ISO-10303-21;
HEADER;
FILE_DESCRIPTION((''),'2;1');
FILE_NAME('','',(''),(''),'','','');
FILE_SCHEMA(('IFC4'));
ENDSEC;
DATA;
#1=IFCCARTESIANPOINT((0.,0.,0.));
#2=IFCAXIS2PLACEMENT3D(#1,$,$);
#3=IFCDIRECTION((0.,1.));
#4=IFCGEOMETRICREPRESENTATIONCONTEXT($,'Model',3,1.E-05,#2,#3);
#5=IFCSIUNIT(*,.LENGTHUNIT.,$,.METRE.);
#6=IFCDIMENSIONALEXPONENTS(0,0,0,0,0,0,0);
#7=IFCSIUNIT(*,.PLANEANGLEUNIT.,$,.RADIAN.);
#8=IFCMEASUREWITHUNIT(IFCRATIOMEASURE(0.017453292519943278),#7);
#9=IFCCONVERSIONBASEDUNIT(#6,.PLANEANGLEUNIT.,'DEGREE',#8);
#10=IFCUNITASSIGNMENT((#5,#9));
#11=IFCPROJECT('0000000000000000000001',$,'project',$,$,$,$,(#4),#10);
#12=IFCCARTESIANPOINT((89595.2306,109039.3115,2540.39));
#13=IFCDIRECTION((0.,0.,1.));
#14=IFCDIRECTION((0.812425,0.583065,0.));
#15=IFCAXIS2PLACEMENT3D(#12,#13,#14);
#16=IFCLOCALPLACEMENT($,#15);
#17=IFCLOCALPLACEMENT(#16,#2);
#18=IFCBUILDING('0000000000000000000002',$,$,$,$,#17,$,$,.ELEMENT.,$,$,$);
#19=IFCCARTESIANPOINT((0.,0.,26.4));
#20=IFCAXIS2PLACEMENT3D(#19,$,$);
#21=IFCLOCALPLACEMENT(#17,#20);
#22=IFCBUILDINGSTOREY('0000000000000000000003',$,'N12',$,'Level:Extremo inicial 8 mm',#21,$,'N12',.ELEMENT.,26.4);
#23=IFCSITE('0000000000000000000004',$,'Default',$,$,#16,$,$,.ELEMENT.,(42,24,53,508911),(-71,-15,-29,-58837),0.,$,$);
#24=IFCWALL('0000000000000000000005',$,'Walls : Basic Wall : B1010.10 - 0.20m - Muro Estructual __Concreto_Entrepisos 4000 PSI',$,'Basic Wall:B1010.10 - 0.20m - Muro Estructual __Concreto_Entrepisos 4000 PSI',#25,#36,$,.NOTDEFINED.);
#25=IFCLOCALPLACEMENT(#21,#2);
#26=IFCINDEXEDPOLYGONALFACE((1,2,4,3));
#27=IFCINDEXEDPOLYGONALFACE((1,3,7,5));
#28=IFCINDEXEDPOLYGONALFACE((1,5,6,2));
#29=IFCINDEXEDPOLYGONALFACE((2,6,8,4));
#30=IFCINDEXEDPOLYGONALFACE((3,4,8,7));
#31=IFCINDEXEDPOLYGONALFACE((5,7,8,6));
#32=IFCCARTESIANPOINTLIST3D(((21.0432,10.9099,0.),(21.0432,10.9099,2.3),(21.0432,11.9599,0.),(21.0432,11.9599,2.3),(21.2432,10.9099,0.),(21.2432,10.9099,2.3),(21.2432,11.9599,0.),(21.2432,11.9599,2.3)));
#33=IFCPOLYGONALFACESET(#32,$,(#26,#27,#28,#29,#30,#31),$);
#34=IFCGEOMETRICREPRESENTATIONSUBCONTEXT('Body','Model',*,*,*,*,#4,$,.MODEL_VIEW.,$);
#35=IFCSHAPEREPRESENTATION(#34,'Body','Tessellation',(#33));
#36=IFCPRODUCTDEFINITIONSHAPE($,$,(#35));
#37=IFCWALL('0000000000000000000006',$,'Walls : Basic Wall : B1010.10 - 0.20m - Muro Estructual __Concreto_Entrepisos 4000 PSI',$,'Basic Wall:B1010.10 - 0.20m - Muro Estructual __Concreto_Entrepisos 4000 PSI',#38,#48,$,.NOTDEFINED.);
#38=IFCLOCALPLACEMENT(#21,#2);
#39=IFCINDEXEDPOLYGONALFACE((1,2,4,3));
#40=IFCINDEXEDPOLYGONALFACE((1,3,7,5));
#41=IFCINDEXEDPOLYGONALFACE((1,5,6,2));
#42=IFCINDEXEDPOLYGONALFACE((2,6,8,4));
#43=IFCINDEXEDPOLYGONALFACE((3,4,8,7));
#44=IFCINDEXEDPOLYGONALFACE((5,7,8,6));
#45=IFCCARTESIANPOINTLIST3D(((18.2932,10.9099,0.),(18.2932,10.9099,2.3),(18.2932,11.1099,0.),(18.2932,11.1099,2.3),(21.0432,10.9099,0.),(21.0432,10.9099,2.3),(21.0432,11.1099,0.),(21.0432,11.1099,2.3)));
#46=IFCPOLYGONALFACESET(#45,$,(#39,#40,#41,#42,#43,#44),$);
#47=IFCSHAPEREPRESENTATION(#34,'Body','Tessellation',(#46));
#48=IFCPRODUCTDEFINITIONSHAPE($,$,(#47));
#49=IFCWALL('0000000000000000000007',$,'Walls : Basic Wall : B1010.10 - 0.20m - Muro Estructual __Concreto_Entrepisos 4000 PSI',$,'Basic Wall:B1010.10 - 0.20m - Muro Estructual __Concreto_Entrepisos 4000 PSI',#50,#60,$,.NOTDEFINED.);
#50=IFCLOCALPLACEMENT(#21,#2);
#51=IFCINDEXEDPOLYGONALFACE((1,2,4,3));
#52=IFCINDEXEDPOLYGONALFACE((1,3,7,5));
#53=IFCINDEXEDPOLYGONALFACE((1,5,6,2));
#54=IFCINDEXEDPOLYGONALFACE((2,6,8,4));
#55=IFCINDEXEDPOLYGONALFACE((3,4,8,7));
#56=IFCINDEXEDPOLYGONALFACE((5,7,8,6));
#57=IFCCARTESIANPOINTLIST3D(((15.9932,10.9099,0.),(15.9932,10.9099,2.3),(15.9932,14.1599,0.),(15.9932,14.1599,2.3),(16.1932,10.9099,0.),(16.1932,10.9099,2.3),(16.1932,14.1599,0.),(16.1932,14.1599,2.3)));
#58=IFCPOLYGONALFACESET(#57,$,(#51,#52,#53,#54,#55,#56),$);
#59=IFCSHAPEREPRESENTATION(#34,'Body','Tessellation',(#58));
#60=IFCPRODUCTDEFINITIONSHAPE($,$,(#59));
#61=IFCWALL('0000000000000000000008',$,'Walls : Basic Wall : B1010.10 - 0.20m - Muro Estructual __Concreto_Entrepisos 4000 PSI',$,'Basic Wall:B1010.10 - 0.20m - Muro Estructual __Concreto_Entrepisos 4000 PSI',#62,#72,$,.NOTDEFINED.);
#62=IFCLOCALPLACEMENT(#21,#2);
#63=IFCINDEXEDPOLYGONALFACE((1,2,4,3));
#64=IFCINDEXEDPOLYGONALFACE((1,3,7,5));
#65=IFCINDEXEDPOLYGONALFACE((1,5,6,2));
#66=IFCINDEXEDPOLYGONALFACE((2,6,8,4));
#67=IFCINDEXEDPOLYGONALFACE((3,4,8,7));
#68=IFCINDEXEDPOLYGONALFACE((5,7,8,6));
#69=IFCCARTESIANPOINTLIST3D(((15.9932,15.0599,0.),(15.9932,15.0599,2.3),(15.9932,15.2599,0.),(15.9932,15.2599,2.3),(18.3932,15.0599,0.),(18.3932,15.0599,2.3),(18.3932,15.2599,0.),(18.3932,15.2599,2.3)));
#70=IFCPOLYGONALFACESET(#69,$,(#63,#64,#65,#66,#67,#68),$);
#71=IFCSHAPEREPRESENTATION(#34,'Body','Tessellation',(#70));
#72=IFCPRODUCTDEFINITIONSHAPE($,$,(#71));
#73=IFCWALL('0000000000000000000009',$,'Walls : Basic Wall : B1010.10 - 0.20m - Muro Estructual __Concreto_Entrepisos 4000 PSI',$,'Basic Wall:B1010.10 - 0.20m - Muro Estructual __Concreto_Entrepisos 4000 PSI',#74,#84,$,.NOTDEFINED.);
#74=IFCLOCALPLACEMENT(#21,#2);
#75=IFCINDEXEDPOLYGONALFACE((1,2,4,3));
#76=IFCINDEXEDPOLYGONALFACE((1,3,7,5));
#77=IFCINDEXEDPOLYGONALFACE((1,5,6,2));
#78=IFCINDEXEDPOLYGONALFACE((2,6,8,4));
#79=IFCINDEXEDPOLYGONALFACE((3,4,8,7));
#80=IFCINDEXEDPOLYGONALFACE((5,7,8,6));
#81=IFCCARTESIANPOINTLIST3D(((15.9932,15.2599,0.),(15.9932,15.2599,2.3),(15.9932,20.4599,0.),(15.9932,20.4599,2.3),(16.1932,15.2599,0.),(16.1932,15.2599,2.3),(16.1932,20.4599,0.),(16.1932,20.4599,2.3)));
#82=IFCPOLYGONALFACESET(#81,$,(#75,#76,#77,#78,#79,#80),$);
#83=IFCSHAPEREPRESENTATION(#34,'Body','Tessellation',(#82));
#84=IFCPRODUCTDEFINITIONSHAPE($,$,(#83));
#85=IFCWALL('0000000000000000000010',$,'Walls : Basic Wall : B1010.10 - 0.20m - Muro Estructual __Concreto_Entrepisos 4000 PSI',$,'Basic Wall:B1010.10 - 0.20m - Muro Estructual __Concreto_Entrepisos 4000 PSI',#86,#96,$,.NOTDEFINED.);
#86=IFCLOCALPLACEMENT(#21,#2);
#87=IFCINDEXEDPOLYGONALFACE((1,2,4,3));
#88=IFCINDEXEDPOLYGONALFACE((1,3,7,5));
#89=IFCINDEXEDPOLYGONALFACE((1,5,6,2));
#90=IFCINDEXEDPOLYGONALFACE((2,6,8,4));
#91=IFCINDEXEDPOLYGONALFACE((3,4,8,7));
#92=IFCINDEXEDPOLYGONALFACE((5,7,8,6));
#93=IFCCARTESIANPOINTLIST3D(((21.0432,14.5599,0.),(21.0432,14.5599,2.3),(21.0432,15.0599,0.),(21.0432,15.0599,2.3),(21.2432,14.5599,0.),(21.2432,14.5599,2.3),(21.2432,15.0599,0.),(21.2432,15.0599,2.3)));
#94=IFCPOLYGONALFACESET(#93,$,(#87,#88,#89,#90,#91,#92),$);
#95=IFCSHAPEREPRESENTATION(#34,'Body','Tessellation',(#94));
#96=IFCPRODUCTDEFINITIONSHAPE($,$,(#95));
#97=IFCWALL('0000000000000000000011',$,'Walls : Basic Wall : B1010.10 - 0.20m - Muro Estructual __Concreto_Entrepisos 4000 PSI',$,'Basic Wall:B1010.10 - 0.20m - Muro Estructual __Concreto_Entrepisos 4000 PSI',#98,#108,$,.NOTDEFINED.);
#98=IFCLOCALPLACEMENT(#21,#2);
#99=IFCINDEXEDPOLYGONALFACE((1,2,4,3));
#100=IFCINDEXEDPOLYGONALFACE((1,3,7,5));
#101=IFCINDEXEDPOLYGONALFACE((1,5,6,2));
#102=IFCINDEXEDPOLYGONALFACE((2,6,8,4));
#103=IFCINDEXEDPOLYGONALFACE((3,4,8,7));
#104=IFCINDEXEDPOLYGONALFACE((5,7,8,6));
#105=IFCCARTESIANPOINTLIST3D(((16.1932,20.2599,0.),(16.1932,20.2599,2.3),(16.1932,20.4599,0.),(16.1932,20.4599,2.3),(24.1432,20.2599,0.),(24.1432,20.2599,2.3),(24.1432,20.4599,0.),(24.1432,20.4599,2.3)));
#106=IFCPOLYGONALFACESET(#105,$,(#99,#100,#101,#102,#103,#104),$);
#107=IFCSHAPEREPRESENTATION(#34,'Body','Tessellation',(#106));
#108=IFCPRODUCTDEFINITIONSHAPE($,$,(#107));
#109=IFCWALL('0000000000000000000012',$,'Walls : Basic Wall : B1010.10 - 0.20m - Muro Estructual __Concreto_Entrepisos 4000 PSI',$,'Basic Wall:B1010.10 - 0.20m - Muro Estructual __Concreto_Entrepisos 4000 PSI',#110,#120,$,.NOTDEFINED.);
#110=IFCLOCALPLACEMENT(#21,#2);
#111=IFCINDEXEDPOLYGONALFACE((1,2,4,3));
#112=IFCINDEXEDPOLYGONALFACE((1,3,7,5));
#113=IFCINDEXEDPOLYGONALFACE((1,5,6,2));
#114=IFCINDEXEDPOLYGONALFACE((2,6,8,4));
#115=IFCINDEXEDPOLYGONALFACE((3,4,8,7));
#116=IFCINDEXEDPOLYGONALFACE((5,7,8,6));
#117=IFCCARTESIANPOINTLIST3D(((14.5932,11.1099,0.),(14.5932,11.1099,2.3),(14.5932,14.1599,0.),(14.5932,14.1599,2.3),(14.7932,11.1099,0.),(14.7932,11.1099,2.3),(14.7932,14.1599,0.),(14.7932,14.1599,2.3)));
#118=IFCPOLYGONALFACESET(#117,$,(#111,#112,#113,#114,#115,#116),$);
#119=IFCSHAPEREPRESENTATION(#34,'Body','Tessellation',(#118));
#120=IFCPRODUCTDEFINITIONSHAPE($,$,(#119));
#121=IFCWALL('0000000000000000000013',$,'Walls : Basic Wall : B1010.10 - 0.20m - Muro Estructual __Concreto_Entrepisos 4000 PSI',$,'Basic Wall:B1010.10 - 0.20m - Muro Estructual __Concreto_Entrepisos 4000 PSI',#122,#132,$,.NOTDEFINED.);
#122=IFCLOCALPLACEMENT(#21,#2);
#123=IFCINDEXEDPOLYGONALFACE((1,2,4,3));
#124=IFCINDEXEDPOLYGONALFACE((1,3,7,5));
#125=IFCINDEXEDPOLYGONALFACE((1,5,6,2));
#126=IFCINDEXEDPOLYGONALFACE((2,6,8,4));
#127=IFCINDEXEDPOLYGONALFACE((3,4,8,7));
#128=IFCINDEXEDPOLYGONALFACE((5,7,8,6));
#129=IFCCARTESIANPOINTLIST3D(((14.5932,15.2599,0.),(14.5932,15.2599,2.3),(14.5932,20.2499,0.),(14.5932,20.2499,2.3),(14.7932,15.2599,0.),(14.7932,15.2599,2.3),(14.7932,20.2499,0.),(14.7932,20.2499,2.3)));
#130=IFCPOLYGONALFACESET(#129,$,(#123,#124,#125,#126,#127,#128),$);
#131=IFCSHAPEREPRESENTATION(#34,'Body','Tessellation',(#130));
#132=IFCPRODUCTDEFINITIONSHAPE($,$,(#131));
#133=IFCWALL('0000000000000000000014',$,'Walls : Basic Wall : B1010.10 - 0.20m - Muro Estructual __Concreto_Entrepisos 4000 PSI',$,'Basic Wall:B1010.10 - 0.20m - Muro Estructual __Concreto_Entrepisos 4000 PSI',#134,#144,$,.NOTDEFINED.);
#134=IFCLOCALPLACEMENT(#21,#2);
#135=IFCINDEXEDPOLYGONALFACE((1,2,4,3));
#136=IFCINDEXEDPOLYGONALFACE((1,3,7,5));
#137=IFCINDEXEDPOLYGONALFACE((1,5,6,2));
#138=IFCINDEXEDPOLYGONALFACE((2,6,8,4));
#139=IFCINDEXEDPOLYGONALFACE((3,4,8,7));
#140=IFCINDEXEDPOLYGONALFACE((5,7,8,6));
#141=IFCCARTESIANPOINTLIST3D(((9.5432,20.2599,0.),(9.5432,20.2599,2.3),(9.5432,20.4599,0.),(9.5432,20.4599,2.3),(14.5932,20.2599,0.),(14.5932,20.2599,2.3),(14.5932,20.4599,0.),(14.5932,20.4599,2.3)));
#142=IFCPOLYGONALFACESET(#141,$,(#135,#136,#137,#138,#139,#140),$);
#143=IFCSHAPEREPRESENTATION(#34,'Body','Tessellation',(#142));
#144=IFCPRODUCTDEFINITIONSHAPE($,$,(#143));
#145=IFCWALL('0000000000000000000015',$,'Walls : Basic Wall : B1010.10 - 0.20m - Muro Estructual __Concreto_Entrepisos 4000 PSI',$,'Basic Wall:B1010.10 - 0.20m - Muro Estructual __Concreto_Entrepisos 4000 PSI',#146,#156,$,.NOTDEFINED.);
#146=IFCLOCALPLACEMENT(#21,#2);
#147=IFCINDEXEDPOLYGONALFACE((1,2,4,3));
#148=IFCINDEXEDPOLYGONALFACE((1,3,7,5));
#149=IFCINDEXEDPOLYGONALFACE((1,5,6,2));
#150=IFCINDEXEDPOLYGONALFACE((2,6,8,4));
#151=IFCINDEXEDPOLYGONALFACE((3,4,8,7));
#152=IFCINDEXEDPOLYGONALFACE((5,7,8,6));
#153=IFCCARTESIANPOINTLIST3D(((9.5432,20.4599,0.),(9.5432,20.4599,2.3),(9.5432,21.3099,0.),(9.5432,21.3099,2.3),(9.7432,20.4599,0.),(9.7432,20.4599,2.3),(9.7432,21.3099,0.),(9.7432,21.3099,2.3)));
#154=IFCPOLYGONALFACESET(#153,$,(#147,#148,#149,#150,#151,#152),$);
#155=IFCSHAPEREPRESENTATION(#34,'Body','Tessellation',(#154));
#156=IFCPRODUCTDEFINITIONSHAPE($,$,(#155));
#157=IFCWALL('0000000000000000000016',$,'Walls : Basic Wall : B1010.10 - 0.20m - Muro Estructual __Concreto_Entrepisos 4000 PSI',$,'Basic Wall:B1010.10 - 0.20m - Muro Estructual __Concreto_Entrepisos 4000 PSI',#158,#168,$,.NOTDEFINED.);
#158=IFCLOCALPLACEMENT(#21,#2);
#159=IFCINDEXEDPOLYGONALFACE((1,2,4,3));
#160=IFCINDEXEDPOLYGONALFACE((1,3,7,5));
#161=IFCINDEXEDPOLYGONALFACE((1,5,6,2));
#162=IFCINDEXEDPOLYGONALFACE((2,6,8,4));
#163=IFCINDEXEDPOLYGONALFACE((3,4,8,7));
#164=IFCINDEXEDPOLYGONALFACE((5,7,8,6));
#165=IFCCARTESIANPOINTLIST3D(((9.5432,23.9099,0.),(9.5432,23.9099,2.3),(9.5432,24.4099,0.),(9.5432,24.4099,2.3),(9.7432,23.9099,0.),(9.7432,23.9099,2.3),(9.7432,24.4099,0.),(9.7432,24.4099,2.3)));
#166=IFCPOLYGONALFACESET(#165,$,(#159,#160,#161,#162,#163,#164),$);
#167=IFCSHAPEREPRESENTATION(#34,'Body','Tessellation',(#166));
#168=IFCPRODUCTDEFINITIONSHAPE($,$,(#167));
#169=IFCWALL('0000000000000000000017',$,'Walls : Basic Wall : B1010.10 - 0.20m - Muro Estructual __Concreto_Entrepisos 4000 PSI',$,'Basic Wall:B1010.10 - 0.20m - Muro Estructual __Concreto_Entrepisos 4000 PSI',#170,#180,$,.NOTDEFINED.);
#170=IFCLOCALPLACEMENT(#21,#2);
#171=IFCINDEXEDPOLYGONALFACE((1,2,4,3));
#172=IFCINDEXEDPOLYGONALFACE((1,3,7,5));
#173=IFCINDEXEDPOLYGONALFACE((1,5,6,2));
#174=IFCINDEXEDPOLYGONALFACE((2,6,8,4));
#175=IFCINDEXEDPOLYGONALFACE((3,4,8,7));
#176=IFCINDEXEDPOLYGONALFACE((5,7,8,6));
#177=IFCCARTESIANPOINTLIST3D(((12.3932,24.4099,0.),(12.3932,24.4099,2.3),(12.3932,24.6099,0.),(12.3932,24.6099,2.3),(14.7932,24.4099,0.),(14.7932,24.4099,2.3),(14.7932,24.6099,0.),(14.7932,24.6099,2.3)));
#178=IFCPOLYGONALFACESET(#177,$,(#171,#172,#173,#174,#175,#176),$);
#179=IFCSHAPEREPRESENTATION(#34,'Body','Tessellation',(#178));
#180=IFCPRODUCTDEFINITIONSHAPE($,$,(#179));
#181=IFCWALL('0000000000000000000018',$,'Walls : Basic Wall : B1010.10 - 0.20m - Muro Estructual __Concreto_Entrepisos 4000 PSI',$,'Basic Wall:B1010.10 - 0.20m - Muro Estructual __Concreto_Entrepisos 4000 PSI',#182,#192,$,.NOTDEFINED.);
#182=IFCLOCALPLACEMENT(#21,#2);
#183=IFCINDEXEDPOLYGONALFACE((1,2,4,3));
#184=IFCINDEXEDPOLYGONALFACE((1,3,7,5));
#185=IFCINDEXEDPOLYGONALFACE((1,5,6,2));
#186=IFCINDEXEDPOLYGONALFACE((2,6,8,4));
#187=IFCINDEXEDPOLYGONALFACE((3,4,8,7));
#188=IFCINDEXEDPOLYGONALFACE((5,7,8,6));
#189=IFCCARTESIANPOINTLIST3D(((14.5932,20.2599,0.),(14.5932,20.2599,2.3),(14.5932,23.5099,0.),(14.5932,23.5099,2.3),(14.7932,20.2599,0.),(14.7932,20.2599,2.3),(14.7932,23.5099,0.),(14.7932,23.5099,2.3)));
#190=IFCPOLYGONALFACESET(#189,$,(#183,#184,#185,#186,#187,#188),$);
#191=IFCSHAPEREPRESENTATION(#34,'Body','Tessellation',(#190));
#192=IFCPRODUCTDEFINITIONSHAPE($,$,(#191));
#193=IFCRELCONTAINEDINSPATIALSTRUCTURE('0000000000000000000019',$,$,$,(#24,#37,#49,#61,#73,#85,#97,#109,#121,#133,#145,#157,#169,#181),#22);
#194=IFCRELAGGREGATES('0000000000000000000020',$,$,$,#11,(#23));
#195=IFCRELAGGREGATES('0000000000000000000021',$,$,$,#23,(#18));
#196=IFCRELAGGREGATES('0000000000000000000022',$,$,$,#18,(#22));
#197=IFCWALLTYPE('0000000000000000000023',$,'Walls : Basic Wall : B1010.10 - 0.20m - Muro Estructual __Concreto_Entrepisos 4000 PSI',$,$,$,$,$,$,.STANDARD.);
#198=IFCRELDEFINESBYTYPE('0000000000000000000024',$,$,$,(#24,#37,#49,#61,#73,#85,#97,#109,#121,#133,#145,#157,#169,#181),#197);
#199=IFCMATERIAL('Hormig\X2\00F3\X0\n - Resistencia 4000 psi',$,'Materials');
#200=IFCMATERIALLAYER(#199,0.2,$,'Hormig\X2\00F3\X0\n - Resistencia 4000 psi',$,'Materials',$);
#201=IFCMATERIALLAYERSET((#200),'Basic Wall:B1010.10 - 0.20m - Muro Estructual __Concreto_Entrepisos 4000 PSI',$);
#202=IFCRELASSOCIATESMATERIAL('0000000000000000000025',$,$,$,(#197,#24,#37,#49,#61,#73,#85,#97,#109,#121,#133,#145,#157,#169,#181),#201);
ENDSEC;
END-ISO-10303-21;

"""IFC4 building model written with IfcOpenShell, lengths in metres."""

from ifc_helpers import new_model, entity, si_unit, converted_unit, direction, frame, frame_2d, origin, place, context, subcontext, project, spatial, rectangle, extrude, material, layer, layer_set, layer_usage, type_object, element, save


model = new_model("IFC4")

# Units and contexts
model_context = context("Model", 3, precision=1e-05, world=origin(), true_north=direction((0.0, 1.0)))
body_context = subcontext(model_context, "Body", "Model", "MODEL_VIEW")
ifc_project = project(units=[si_unit("LENGTHUNIT", "METRE"), converted_unit("PLANEANGLEUNIT", "DEGREE", entity("IfcRatioMeasure", 0.017453292519943278), si_unit("PLANEANGLEUNIT", "RADIAN"), dimensions=[0, 0, 0, 0, 0, 0, 0])], contexts=[model_context])

# Site, building, storey
site_placement = place(None, frame((89595.2306, 109039.3115, 2540.39), z_axis=(0.0, 0.0, 1.0), x_axis=(0.812425, 0.583065, 0.0)))
site = spatial("IfcSite", under=ifc_project, at=site_placement, Name="Default", CompositionType="ELEMENT", RefLatitude=(42, 24, 53, 508911), RefLongitude=(-71, -15, -29, -58837), RefElevation=0.0)
building_placement = place(site_placement, origin())
building = spatial("IfcBuilding", under=site, at=building_placement, CompositionType="ELEMENT")
storey_placement = place(building_placement, frame((0.0, 0.0, 26.4)))
storey = spatial("IfcBuildingStorey", under=building, at=storey_placement, Name="N12", ObjectType="Level:Extremo inicial 8 mm", LongName="N12", CompositionType="ELEMENT", Elevation=26.4)

# Walls
ifc_material = material(Name="Hormigón - Resistencia 4000 psi", Category="Materials")
ifc_layer_1 = layer(ifc_material, 0.2, Name="Hormigón - Resistencia 4000 psi", Category="Materials")
ifc_layer_set_1 = layer_set([ifc_layer_1], Name="Basic Wall:B1010.10 - 0.20m - Muro Estructual __Concreto_Entrepisos 4000 PSI")
ifc_layer_usage_1 = layer_usage(ifc_layer_set_1, "AXIS2", "NEGATIVE", 0.1)
wall_type_1 = type_object("IfcWallType", Name="Walls : Basic Wall : B1010.10 - 0.20m - Muro Estructual __Concreto_Entrepisos 4000 PSI", PredefinedType="STANDARD", material=ifc_layer_set_1)
wall_1_placement = place(storey_placement, frame((21.1432, 11.9599, 0.0), z_axis=(0.0, 0.0, 1.0), x_axis=(0.0, -1.0, 0.0)))
element("IfcWall", 1, at=wall_1_placement, inside=storey, type_object=wall_type_1, material=ifc_layer_usage_1, Name="Walls : Basic Wall : B1010.10 - 0.20m - Muro Estructual __Concreto_Entrepisos 4000 PSI", ObjectType="Basic Wall:B1010.10 - 0.20m - Muro Estructual __Concreto_Entrepisos 4000 PSI", PredefinedType="NOTDEFINED", context=body_context, shape_type="SweptSolid", body=[
    extrude(rectangle(XDim=1.05, YDim=0.2, at=frame_2d((0.525, 0.0), x_axis=(-1.0, 0.0))), origin(), (0.0, 0.0, 1.0), 2.3),
])
ifc_layer_usage_2 = layer_usage(ifc_layer_set_1, "AXIS2", "NEGATIVE", 0.1)
wall_2_placement = place(storey_placement, frame((21.0432, 11.0099, 0.0), z_axis=(0.0, 0.0, 1.0), x_axis=(-1.0, 0.0, 0.0)))
element("IfcWall", 2, at=wall_2_placement, inside=storey, type_object=wall_type_1, material=ifc_layer_usage_2, Name="Walls : Basic Wall : B1010.10 - 0.20m - Muro Estructual __Concreto_Entrepisos 4000 PSI", ObjectType="Basic Wall:B1010.10 - 0.20m - Muro Estructual __Concreto_Entrepisos 4000 PSI", PredefinedType="NOTDEFINED", context=body_context, shape_type="SweptSolid", body=[
    extrude(rectangle(XDim=2.75, YDim=0.2, at=frame_2d((1.375, 0.0), x_axis=(-1.0, 0.0))), origin(), (0.0, 0.0, 1.0), 2.3),
])
ifc_layer_usage_3 = layer_usage(ifc_layer_set_1, "AXIS2", "NEGATIVE", 0.1)
wall_3_placement = place(storey_placement, frame((16.0932, 14.1599, 0.0), z_axis=(0.0, 0.0, 1.0), x_axis=(0.0, -1.0, 0.0)))
element("IfcWall", 3, at=wall_3_placement, inside=storey, type_object=wall_type_1, material=ifc_layer_usage_3, Name="Walls : Basic Wall : B1010.10 - 0.20m - Muro Estructual __Concreto_Entrepisos 4000 PSI", ObjectType="Basic Wall:B1010.10 - 0.20m - Muro Estructual __Concreto_Entrepisos 4000 PSI", PredefinedType="NOTDEFINED", context=body_context, shape_type="SweptSolid", body=[
    extrude(rectangle(XDim=3.25, YDim=0.2, at=frame_2d((1.625, 0.0), x_axis=(-1.0, 0.0))), origin(), (0.0, 0.0, 1.0), 2.3),
])
ifc_layer_usage_4 = layer_usage(ifc_layer_set_1, "AXIS2", "NEGATIVE", 0.1)
wall_4_placement = place(storey_placement, frame((18.3932, 15.1599, 0.0), z_axis=(0.0, 0.0, 1.0), x_axis=(-1.0, 0.0, 0.0)))
element("IfcWall", 4, at=wall_4_placement, inside=storey, type_object=wall_type_1, material=ifc_layer_usage_4, Name="Walls : Basic Wall : B1010.10 - 0.20m - Muro Estructual __Concreto_Entrepisos 4000 PSI", ObjectType="Basic Wall:B1010.10 - 0.20m - Muro Estructual __Concreto_Entrepisos 4000 PSI", PredefinedType="NOTDEFINED", context=body_context, shape_type="SweptSolid", body=[
    extrude(rectangle(XDim=2.4, YDim=0.2, at=frame_2d((1.2, 0.0), x_axis=(-1.0, 0.0))), origin(), (0.0, 0.0, 1.0), 2.3),
])
ifc_layer_usage_5 = layer_usage(ifc_layer_set_1, "AXIS2", "NEGATIVE", 0.1)
wall_5_placement = place(storey_placement, frame((16.0932, 15.2599, 0.0), z_axis=(0.0, 0.0, 1.0), x_axis=(0.0, 1.0, 0.0)))
element("IfcWall", 5, at=wall_5_placement, inside=storey, type_object=wall_type_1, material=ifc_layer_usage_5, Name="Walls : Basic Wall : B1010.10 - 0.20m - Muro Estructual __Concreto_Entrepisos 4000 PSI", ObjectType="Basic Wall:B1010.10 - 0.20m - Muro Estructual __Concreto_Entrepisos 4000 PSI", PredefinedType="NOTDEFINED", context=body_context, shape_type="SweptSolid", body=[
    extrude(rectangle(XDim=5.2, YDim=0.2, at=frame_2d((2.6, 0.0), x_axis=(-1.0, 0.0))), origin(), (0.0, 0.0, 1.0), 2.3),
])
ifc_layer_usage_6 = layer_usage(ifc_layer_set_1, "AXIS2", "NEGATIVE", 0.1)
wall_6_placement = place(storey_placement, frame((21.1432, 14.5599, 0.0), z_axis=(0.0, 0.0, 1.0), x_axis=(0.0, 1.0, 0.0)))
element("IfcWall", 6, at=wall_6_placement, inside=storey, type_object=wall_type_1, material=ifc_layer_usage_6, Name="Walls : Basic Wall : B1010.10 - 0.20m - Muro Estructual __Concreto_Entrepisos 4000 PSI", ObjectType="Basic Wall:B1010.10 - 0.20m - Muro Estructual __Concreto_Entrepisos 4000 PSI", PredefinedType="NOTDEFINED", context=body_context, shape_type="SweptSolid", body=[
    extrude(rectangle(XDim=0.5, YDim=0.2, at=frame_2d((0.25, 0.0), x_axis=(-1.0, 0.0))), origin(), (0.0, 0.0, 1.0), 2.3),
])
ifc_layer_usage_7 = layer_usage(ifc_layer_set_1, "AXIS2", "NEGATIVE", 0.1)
wall_7_placement = place(storey_placement, frame((16.1932, 20.3599, 0.0)))
element("IfcWall", 7, at=wall_7_placement, inside=storey, type_object=wall_type_1, material=ifc_layer_usage_7, Name="Walls : Basic Wall : B1010.10 - 0.20m - Muro Estructual __Concreto_Entrepisos 4000 PSI", ObjectType="Basic Wall:B1010.10 - 0.20m - Muro Estructual __Concreto_Entrepisos 4000 PSI", PredefinedType="NOTDEFINED", context=body_context, shape_type="SweptSolid", body=[
    extrude(rectangle(XDim=7.95, YDim=0.2, at=frame_2d((3.975, 0.0), x_axis=(-1.0, 0.0))), origin(), (0.0, 0.0, 1.0), 2.3),
])
ifc_layer_usage_8 = layer_usage(ifc_layer_set_1, "AXIS2", "POSITIVE", -0.1)
wall_8_placement = place(storey_placement, frame((14.6932, 14.1599, 0.0), z_axis=(0.0, 0.0, 1.0), x_axis=(0.0, -1.0, 0.0)))
element("IfcWall", 8, at=wall_8_placement, inside=storey, type_object=wall_type_1, material=ifc_layer_usage_8, Name="Walls : Basic Wall : B1010.10 - 0.20m - Muro Estructual __Concreto_Entrepisos 4000 PSI", ObjectType="Basic Wall:B1010.10 - 0.20m - Muro Estructual __Concreto_Entrepisos 4000 PSI", PredefinedType="NOTDEFINED", context=body_context, shape_type="SweptSolid", body=[
    extrude(rectangle(XDim=3.05, YDim=0.2, at=frame_2d((1.525, 0.0), x_axis=(-1.0, 0.0))), origin(), (0.0, 0.0, 1.0), 2.3),
])
ifc_layer_usage_9 = layer_usage(ifc_layer_set_1, "AXIS2", "POSITIVE", -0.1)
wall_9_placement = place(storey_placement, frame((14.6932, 15.2599, 0.0), z_axis=(0.0, 0.0, 1.0), x_axis=(0.0, 1.0, 0.0)))
element("IfcWall", 9, at=wall_9_placement, inside=storey, type_object=wall_type_1, material=ifc_layer_usage_9, Name="Walls : Basic Wall : B1010.10 - 0.20m - Muro Estructual __Concreto_Entrepisos 4000 PSI", ObjectType="Basic Wall:B1010.10 - 0.20m - Muro Estructual __Concreto_Entrepisos 4000 PSI", PredefinedType="NOTDEFINED", context=body_context, shape_type="SweptSolid", body=[
    extrude(rectangle(XDim=4.99, YDim=0.2, at=frame_2d((2.495, 0.0), x_axis=(-1.0, 0.0))), origin(), (0.0, 0.0, 1.0), 2.3),
])
ifc_layer_usage_10 = layer_usage(ifc_layer_set_1, "AXIS2", "POSITIVE", -0.1)
wall_10_placement = place(storey_placement, frame((14.5932, 20.3599, 0.0), z_axis=(0.0, 0.0, 1.0), x_axis=(-1.0, 0.0, 0.0)))
element("IfcWall", 10, at=wall_10_placement, inside=storey, type_object=wall_type_1, material=ifc_layer_usage_10, Name="Walls : Basic Wall : B1010.10 - 0.20m - Muro Estructual __Concreto_Entrepisos 4000 PSI", ObjectType="Basic Wall:B1010.10 - 0.20m - Muro Estructual __Concreto_Entrepisos 4000 PSI", PredefinedType="NOTDEFINED", context=body_context, shape_type="SweptSolid", body=[
    extrude(rectangle(XDim=5.05, YDim=0.2, at=frame_2d((2.525, 0.0), x_axis=(-1.0, 0.0))), origin(), (0.0, 0.0, 1.0), 2.3),
])
ifc_layer_usage_11 = layer_usage(ifc_layer_set_1, "AXIS2", "NEGATIVE", 0.1)
wall_11_placement = place(storey_placement, frame((9.6432, 20.4599, 0.0), z_axis=(0.0, 0.0, 1.0), x_axis=(0.0, 1.0, 0.0)))
element("IfcWall", 11, at=wall_11_placement, inside=storey, type_object=wall_type_1, material=ifc_layer_usage_11, Name="Walls : Basic Wall : B1010.10 - 0.20m - Muro Estructual __Concreto_Entrepisos 4000 PSI", ObjectType="Basic Wall:B1010.10 - 0.20m - Muro Estructual __Concreto_Entrepisos 4000 PSI", PredefinedType="NOTDEFINED", context=body_context, shape_type="SweptSolid", body=[
    extrude(rectangle(XDim=0.85, YDim=0.2, at=frame_2d((0.425, 0.0), x_axis=(-1.0, 0.0))), origin(), (0.0, 0.0, 1.0), 2.3),
])
ifc_layer_usage_12 = layer_usage(ifc_layer_set_1, "AXIS2", "NEGATIVE", 0.1)
wall_12_placement = place(storey_placement, frame((9.6432, 23.9099, 0.0), z_axis=(0.0, 0.0, 1.0), x_axis=(0.0, 1.0, 0.0)))
element("IfcWall", 12, at=wall_12_placement, inside=storey, type_object=wall_type_1, material=ifc_layer_usage_12, Name="Walls : Basic Wall : B1010.10 - 0.20m - Muro Estructual __Concreto_Entrepisos 4000 PSI", ObjectType="Basic Wall:B1010.10 - 0.20m - Muro Estructual __Concreto_Entrepisos 4000 PSI", PredefinedType="NOTDEFINED", context=body_context, shape_type="SweptSolid", body=[
    extrude(rectangle(XDim=0.5, YDim=0.2, at=frame_2d((0.25, 0.0), x_axis=(-1.0, 0.0))), origin(), (0.0, 0.0, 1.0), 2.3),
])
ifc_layer_usage_13 = layer_usage(ifc_layer_set_1, "AXIS2", "NEGATIVE", 0.1)
wall_13_placement = place(storey_placement, frame((12.3932, 24.5099, 0.0)))
element("IfcWall", 13, at=wall_13_placement, inside=storey, type_object=wall_type_1, material=ifc_layer_usage_13, Name="Walls : Basic Wall : B1010.10 - 0.20m - Muro Estructual __Concreto_Entrepisos 4000 PSI", ObjectType="Basic Wall:B1010.10 - 0.20m - Muro Estructual __Concreto_Entrepisos 4000 PSI", PredefinedType="NOTDEFINED", context=body_context, shape_type="SweptSolid", body=[
    extrude(rectangle(XDim=2.4, YDim=0.2, at=frame_2d((1.2, 0.0), x_axis=(-1.0, 0.0))), origin(), (0.0, 0.0, 1.0), 2.3),
])
ifc_layer_usage_14 = layer_usage(ifc_layer_set_1, "AXIS2", "POSITIVE", -0.1)
wall_14_placement = place(storey_placement, frame((14.6932, 20.2599, 0.0), z_axis=(0.0, 0.0, 1.0), x_axis=(0.0, 1.0, 0.0)))
element("IfcWall", 14, at=wall_14_placement, inside=storey, type_object=wall_type_1, material=ifc_layer_usage_14, Name="Walls : Basic Wall : B1010.10 - 0.20m - Muro Estructual __Concreto_Entrepisos 4000 PSI", ObjectType="Basic Wall:B1010.10 - 0.20m - Muro Estructual __Concreto_Entrepisos 4000 PSI", PredefinedType="NOTDEFINED", context=body_context, shape_type="SweptSolid", body=[
    extrude(rectangle(XDim=3.25, YDim=0.2, at=frame_2d((1.625, 0.0), x_axis=(-1.0, 0.0))), origin(), (0.0, 0.0, 1.0), 2.3),
])

save(model, "model.ifc")
